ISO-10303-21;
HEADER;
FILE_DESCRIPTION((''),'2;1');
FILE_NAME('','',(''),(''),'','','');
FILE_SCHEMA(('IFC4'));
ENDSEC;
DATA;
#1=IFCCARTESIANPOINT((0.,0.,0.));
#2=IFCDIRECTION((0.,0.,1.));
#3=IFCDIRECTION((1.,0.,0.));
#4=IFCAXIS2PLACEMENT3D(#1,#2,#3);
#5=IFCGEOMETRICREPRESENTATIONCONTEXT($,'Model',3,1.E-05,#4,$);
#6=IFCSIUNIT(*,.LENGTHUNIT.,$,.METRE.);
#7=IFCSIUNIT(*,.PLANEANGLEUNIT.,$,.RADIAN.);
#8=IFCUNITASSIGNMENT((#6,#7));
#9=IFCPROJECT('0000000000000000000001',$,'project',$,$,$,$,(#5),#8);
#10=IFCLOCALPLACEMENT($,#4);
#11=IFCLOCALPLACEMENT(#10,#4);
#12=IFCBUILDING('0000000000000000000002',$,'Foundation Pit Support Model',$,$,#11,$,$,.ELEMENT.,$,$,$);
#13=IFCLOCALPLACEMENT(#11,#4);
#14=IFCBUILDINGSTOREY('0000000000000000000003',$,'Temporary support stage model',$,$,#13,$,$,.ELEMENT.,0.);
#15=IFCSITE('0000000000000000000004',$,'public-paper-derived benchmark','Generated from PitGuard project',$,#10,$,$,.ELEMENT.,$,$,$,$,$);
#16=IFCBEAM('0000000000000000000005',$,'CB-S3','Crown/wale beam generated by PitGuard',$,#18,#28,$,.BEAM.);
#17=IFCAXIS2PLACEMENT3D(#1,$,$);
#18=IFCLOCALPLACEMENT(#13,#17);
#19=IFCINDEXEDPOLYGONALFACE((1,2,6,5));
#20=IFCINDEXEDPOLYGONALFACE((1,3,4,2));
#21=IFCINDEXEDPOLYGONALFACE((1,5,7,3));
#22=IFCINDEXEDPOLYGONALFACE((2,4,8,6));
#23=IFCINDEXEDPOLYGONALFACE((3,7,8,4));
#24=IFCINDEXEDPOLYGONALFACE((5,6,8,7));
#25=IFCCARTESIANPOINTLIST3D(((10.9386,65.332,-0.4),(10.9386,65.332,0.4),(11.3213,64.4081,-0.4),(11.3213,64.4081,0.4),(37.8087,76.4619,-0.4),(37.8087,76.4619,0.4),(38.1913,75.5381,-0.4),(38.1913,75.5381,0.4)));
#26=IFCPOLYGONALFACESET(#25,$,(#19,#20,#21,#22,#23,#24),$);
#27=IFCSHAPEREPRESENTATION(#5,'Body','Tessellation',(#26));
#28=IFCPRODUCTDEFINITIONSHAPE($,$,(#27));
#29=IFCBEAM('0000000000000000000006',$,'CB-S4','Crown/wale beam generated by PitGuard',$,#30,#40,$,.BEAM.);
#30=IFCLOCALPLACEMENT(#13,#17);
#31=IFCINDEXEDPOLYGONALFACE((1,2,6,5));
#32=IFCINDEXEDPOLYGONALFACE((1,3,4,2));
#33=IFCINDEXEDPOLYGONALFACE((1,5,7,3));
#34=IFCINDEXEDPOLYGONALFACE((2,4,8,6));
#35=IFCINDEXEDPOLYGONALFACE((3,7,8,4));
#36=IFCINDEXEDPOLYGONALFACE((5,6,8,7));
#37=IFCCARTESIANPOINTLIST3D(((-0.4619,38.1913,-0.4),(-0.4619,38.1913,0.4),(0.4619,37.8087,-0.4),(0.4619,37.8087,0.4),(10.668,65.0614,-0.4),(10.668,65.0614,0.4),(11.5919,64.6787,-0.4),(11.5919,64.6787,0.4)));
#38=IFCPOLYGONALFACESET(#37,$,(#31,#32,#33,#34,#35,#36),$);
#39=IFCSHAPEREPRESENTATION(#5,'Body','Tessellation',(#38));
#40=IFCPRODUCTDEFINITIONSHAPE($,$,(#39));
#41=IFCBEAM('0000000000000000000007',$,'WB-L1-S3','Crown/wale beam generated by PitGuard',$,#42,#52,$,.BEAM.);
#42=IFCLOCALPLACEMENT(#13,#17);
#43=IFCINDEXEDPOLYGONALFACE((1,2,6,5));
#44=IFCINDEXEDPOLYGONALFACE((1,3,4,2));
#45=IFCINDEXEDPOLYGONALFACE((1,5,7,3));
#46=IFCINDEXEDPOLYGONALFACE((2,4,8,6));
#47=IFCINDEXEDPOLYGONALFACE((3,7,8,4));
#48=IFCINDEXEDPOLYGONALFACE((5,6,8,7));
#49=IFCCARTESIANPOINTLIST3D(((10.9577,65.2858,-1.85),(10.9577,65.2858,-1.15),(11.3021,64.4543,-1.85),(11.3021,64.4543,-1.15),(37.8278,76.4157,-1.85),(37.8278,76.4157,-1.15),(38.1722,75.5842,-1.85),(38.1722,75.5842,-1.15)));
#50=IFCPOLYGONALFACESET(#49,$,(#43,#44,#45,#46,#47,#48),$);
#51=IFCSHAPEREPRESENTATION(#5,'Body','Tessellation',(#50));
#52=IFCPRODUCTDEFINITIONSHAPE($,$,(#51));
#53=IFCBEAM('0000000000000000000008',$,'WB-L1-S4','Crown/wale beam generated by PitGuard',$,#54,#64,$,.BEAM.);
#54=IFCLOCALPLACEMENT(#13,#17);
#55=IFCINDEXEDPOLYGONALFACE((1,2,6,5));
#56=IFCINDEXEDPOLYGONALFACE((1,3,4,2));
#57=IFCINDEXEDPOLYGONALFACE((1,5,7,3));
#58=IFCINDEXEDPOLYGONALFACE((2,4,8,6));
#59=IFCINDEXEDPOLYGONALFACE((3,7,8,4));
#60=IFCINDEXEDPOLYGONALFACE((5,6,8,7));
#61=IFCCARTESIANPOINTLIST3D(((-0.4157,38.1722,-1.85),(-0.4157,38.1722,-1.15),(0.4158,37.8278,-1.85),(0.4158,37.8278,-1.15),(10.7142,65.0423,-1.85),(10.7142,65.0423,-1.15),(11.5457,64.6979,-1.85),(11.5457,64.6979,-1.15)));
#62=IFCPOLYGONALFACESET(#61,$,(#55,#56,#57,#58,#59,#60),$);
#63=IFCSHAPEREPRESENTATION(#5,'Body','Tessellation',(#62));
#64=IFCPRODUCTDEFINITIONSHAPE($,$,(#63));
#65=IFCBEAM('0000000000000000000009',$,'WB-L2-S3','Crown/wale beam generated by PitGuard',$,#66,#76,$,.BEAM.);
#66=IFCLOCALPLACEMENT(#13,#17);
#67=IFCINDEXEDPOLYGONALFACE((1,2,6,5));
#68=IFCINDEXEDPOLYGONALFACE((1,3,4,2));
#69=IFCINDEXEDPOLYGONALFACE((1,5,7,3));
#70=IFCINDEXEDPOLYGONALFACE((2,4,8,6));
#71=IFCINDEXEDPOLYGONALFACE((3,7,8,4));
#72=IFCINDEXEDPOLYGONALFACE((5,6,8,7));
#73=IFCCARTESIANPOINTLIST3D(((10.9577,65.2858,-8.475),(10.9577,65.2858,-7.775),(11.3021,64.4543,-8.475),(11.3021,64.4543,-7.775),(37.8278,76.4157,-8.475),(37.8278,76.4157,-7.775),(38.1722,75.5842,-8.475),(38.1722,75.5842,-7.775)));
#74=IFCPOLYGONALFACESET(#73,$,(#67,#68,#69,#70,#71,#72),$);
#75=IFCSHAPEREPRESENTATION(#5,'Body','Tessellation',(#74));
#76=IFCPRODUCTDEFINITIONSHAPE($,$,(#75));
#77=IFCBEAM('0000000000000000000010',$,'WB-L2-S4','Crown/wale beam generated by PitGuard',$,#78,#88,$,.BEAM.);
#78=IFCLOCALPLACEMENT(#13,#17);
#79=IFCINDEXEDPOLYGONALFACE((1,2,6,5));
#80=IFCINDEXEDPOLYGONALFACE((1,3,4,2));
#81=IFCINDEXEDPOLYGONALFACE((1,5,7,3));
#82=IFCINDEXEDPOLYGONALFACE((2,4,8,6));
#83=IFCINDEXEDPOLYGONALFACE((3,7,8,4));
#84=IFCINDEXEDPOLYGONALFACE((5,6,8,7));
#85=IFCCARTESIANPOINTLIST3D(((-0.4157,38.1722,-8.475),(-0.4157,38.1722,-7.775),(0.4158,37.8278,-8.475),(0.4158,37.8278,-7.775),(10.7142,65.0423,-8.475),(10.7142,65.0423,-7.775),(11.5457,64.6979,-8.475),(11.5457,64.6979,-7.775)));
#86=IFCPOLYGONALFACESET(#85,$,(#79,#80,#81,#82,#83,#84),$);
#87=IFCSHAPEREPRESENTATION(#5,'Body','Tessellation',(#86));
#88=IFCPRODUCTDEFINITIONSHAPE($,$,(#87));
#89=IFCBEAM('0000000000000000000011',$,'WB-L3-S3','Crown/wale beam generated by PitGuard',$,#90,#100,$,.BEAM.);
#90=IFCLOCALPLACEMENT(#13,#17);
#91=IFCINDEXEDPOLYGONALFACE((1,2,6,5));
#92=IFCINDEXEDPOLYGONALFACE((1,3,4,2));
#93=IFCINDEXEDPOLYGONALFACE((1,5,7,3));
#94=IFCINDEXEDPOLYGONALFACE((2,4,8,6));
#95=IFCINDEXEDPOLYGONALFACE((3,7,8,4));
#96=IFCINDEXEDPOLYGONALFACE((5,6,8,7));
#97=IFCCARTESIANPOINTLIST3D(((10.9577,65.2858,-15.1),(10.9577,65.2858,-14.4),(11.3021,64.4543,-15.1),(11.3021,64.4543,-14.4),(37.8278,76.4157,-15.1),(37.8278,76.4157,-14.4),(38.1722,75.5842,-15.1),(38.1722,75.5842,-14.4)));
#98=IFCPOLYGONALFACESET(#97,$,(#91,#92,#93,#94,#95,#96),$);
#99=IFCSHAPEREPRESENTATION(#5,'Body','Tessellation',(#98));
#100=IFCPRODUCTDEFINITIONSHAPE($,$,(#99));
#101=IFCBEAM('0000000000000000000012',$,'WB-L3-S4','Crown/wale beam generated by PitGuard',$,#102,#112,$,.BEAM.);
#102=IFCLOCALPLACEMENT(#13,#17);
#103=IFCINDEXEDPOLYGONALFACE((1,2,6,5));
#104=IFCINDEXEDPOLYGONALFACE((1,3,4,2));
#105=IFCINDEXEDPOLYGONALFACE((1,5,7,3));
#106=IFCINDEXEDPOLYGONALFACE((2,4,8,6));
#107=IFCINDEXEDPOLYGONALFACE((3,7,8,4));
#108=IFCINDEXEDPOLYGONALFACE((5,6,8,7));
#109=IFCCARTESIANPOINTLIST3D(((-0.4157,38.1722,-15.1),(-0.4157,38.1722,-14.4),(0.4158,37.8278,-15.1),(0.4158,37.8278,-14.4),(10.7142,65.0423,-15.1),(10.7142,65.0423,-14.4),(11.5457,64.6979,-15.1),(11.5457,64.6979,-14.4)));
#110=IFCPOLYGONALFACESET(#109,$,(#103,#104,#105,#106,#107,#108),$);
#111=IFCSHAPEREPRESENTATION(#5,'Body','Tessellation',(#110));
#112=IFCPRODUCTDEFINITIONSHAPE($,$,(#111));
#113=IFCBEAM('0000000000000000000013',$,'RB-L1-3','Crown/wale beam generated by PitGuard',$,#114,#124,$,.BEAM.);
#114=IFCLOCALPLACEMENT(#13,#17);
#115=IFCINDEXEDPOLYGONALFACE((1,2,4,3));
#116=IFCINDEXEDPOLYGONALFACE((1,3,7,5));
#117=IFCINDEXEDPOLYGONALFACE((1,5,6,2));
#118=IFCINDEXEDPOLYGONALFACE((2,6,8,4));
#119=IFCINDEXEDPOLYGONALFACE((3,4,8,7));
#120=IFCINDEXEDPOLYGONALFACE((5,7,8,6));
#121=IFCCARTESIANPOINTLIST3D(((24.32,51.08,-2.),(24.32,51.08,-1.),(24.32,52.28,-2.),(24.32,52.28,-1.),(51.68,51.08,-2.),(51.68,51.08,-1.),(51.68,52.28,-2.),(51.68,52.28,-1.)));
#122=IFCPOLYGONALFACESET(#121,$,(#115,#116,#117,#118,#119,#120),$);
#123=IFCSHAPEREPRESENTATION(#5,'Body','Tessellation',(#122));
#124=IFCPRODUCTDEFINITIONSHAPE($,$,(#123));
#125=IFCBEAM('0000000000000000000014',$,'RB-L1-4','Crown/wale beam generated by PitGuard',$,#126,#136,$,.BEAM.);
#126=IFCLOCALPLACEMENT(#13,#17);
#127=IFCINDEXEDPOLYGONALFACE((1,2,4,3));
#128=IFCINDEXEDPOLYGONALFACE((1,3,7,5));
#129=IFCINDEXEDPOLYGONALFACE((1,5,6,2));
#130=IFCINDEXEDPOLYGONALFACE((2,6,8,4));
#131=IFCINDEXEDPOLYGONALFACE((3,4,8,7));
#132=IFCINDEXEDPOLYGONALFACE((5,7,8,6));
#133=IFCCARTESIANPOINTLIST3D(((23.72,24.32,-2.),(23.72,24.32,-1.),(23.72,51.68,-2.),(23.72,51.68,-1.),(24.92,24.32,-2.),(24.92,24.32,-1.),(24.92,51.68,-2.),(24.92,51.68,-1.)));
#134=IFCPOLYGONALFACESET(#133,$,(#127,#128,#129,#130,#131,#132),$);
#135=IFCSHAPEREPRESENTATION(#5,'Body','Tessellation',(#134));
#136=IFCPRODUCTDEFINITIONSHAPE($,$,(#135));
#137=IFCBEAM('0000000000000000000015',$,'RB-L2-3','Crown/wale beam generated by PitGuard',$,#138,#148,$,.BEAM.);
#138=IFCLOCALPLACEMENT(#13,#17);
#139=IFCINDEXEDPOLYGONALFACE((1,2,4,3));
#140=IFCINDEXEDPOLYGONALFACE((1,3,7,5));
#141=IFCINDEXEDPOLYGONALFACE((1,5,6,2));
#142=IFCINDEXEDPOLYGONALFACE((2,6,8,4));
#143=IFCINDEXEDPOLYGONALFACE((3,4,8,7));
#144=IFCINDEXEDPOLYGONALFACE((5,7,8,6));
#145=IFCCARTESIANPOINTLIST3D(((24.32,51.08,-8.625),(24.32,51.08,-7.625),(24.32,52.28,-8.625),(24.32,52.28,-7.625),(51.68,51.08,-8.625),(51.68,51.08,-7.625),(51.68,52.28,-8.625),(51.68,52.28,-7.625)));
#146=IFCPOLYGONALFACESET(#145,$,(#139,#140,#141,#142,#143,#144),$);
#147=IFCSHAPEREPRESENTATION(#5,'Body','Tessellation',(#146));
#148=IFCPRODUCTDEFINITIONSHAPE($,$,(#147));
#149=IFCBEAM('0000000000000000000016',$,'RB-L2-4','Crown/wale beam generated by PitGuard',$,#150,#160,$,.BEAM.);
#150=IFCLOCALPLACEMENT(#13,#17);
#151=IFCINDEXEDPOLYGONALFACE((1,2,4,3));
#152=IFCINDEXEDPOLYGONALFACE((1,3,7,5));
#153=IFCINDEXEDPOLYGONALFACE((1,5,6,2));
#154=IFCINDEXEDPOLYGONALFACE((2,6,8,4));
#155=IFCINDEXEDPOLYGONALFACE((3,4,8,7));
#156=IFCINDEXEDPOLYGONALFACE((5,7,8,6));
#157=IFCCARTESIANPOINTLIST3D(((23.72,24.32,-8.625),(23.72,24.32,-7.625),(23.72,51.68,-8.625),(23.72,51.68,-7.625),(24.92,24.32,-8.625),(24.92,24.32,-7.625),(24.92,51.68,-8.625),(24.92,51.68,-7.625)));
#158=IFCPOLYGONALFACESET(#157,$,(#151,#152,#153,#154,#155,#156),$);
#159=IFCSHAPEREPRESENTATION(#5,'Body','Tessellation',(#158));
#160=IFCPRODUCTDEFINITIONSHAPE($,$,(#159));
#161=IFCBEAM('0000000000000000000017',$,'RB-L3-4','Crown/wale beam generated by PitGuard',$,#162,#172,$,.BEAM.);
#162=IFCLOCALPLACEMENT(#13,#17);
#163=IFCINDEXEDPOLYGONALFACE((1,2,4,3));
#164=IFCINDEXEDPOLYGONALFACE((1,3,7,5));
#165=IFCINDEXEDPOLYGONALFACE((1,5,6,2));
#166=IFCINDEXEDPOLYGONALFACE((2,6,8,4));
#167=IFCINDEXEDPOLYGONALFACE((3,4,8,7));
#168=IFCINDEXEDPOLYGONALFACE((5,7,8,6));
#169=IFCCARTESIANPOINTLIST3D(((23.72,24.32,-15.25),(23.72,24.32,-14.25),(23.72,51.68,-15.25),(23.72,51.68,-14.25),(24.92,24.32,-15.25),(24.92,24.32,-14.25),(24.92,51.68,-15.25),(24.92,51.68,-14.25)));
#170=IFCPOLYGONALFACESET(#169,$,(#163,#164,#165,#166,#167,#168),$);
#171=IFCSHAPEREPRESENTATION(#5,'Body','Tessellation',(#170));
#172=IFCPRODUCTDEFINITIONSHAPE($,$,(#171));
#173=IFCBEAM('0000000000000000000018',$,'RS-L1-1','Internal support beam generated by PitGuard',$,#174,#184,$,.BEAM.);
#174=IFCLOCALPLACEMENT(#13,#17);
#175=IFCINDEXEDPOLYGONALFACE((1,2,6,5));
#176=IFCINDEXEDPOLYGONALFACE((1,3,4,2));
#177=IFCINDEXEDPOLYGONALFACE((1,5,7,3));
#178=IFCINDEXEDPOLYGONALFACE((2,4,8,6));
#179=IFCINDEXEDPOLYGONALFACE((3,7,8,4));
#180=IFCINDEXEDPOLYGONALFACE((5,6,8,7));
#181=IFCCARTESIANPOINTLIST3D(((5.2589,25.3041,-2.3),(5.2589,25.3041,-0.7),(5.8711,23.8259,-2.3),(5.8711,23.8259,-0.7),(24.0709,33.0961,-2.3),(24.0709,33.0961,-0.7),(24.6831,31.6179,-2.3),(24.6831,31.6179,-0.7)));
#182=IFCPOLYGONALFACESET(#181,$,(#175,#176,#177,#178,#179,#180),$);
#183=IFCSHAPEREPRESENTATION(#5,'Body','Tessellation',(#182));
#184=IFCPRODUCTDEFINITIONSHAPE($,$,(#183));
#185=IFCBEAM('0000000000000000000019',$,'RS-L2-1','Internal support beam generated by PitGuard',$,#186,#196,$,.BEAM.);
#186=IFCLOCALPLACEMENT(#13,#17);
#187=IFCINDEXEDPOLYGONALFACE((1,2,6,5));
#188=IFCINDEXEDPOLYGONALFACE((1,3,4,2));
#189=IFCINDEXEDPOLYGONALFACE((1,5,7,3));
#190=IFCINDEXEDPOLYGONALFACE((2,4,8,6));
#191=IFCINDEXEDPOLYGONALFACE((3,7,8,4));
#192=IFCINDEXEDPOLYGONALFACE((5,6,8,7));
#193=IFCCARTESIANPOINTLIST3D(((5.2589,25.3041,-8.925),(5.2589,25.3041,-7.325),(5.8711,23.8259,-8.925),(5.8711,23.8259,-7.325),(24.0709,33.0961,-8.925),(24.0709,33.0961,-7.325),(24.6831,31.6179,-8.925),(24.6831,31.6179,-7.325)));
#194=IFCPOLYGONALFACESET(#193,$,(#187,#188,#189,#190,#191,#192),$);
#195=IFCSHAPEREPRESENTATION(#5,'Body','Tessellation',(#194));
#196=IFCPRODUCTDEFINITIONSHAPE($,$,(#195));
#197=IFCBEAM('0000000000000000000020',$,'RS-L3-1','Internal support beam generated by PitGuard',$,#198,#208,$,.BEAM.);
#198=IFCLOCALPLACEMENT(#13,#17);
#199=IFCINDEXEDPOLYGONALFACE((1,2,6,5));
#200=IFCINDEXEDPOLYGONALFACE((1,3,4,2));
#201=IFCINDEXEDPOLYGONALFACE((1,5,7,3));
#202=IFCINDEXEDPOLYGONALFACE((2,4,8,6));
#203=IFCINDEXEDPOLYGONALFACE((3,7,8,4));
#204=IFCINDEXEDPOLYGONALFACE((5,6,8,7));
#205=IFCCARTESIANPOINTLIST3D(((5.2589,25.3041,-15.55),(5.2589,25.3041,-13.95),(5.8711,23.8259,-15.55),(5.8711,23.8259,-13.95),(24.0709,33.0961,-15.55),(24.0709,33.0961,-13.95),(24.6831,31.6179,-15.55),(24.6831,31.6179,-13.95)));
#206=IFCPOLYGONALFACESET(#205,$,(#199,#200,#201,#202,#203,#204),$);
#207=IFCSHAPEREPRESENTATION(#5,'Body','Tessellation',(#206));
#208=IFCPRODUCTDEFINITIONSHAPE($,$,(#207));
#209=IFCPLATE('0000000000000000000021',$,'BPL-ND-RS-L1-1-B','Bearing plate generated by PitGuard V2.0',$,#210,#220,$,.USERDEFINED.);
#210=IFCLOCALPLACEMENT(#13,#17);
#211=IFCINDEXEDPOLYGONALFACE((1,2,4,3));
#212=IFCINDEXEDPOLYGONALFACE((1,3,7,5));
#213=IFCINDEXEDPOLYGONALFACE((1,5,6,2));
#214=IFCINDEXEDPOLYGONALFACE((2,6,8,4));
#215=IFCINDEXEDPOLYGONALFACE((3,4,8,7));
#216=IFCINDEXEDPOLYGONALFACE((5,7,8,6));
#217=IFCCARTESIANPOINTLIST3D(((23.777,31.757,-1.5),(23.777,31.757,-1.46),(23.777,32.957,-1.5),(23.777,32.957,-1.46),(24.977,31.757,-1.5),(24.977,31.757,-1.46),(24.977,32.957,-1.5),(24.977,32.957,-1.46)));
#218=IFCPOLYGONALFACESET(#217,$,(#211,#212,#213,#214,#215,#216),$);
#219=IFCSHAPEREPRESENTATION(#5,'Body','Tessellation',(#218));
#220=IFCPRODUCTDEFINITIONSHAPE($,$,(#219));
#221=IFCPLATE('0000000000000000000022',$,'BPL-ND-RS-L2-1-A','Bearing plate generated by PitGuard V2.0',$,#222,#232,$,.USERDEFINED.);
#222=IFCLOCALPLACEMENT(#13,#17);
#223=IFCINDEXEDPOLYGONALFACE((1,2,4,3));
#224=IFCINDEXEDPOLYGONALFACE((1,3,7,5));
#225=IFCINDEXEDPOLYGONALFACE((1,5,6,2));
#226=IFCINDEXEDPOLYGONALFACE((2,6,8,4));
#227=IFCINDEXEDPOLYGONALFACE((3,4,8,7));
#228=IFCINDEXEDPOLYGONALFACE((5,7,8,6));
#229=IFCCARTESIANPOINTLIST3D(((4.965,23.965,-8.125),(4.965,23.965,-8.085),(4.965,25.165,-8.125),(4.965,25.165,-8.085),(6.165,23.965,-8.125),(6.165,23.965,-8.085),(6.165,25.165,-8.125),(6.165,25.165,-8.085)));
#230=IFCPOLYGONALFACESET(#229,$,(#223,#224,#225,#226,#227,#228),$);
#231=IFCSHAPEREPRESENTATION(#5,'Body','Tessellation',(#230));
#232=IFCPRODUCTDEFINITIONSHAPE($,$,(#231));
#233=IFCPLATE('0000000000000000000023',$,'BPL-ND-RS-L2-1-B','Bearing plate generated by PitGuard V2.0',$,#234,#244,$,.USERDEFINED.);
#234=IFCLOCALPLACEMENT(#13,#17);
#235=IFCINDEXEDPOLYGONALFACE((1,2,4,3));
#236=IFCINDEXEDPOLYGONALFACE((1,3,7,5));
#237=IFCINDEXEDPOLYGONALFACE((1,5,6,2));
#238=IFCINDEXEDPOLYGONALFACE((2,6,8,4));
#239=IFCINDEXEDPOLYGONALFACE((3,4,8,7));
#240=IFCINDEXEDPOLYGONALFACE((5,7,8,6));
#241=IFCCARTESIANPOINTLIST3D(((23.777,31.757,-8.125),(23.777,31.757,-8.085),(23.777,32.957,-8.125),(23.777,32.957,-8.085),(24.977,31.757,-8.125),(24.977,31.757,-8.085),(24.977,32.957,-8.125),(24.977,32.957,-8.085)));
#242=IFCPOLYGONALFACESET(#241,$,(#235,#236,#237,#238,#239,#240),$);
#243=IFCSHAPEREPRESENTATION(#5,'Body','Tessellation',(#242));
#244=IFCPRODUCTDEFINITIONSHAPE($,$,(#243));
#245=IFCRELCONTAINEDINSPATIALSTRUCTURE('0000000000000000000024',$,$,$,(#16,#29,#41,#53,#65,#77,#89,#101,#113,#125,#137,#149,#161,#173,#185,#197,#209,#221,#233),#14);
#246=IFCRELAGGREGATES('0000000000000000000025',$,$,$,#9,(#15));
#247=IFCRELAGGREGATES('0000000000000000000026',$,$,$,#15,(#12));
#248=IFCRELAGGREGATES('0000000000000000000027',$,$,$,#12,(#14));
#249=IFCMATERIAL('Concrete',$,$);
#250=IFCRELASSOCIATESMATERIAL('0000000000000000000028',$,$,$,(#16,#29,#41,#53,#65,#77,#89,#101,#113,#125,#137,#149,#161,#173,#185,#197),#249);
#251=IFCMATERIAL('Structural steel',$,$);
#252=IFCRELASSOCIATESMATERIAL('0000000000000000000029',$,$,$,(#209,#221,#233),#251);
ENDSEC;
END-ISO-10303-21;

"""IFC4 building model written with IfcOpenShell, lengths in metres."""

from ifc_helpers import new_model, si_unit, frame, origin_with_axes, origin_2d, place, context, project, spatial, rectangle, extrude, material, element, save


model = new_model("IFC4")

# Units and contexts
model_context = context("Model", 3, precision=1e-05, world=origin_with_axes())
ifc_project = project(units=[si_unit("LENGTHUNIT", "METRE"), si_unit("PLANEANGLEUNIT", "RADIAN")], contexts=[model_context])

# Site, building, storey
site_placement = place(None, origin_with_axes())
site = spatial("IfcSite", under=ifc_project, at=site_placement, Name="public-paper-derived benchmark", Description="Generated from PitGuard project", CompositionType="ELEMENT")
building_placement = place(site_placement, origin_with_axes())
building = spatial("IfcBuilding", under=site, at=building_placement, Name="Foundation Pit Support Model", CompositionType="ELEMENT")
storey_placement = place(building_placement, origin_with_axes())
storey = spatial("IfcBuildingStorey", under=building, at=storey_placement, Name="Temporary support stage model", CompositionType="ELEMENT", Elevation=0.0)

# Beams
ifc_material_1 = material(Name="Concrete")
for number, where, z_axis, x_axis, name in (
    (1, (24.565, 70.435, -0.4), (0.0, 0.0, 1.0), (-0.92388, -0.382683, 0.0), "CB-S3"),
    (2, (5.565, 51.435, -0.4), (0.0, 0.0, 1.0), (-0.382683, -0.92388, 0.0), "CB-S4"),
):
    element("IfcBeam", number, at=place(storey_placement, frame(where, z_axis=z_axis, x_axis=x_axis)), inside=storey, material=ifc_material_1, Name=name, Description="Crown/wale beam generated by PitGuard", PredefinedType="BEAM", context=model_context, shape_type="SweptSolid", body=[
        extrude(rectangle(XDim=29.0839, YDim=1.0, at=origin_2d()), origin_with_axes(), (0.0, 0.0, 1.0), 0.8),
    ])
for number, where, z_axis, x_axis, name in (
    (3, (24.565, 70.435, -1.85), (0.0, 0.0, 1.0), (-0.92388, -0.382683, 0.0), "WB-L1-S3"),
    (4, (5.565, 51.435, -1.85), (0.0, 0.0, 1.0), (-0.382683, -0.92388, 0.0), "WB-L1-S4"),
    (5, (24.565, 70.435, -8.475), (0.0, 0.0, 1.0), (-0.92388, -0.382683, 0.0), "WB-L2-S3"),
    (6, (5.565, 51.435, -8.475), (0.0, 0.0, 1.0), (-0.382683, -0.92388, 0.0), "WB-L2-S4"),
    (7, (24.565, 70.435, -15.1), (0.0, 0.0, 1.0), (-0.92388, -0.382683, 0.0), "WB-L3-S3"),
    (8, (5.565, 51.435, -15.1), (0.0, 0.0, 1.0), (-0.382683, -0.92388, 0.0), "WB-L3-S4"),
):
    element("IfcBeam", number, at=place(storey_placement, frame(where, z_axis=z_axis, x_axis=x_axis)), inside=storey, material=ifc_material_1, Name=name, Description="Crown/wale beam generated by PitGuard", PredefinedType="BEAM", context=model_context, shape_type="SweptSolid", body=[
        extrude(rectangle(XDim=29.0839, YDim=0.9, at=origin_2d()), origin_with_axes(), (0.0, 0.0, 1.0), 0.7),
    ])
for number, where, z_axis, x_axis, name in (
    (9, (38.0, 51.68, -2.0), (0.0, 0.0, 1.0), (-1.0, 0.0, 0.0), "RB-L1-3"),
    (10, (24.32, 38.0, -2.0), (0.0, 0.0, 1.0), (0.0, -1.0, 0.0), "RB-L1-4"),
    (11, (38.0, 51.68, -8.625), (0.0, 0.0, 1.0), (-1.0, 0.0, 0.0), "RB-L2-3"),
    (12, (24.32, 38.0, -8.625), (0.0, 0.0, 1.0), (0.0, -1.0, 0.0), "RB-L2-4"),
    (13, (24.32, 38.0, -15.25), (0.0, 0.0, 1.0), (0.0, -1.0, 0.0), "RB-L3-4"),
):
    element("IfcBeam", number, at=place(storey_placement, frame(where, z_axis=z_axis, x_axis=x_axis)), inside=storey, material=ifc_material_1, Name=name, Description="Crown/wale beam generated by PitGuard", PredefinedType="BEAM", context=model_context, shape_type="SweptSolid", body=[
        extrude(rectangle(XDim=27.36, YDim=1.2, at=origin_2d()), origin_with_axes(), (0.0, 0.0, 1.0), 1.0),
    ])
for number, where, z_axis, x_axis, name in (
    (14, (14.971, 28.461, -2.3), (0.0, 0.0, 1.0), (0.923883, 0.382676, 0.0), "RS-L1-1"),
    (15, (14.971, 28.461, -8.925), (0.0, 0.0, 1.0), (0.923883, 0.382676, 0.0), "RS-L2-1"),
    (16, (14.971, 28.461, -15.55), (0.0, 0.0, 1.0), (0.923883, 0.382676, 0.0), "RS-L3-1"),
):
    element("IfcBeam", number, at=place(storey_placement, frame(where, z_axis=z_axis, x_axis=x_axis)), inside=storey, material=ifc_material_1, Name=name, Description="Internal support beam generated by PitGuard", PredefinedType="BEAM", context=model_context, shape_type="SweptSolid", body=[
        extrude(rectangle(XDim=20.3619, YDim=1.6, at=origin_2d()), origin_with_axes(), (0.0, 0.0, 1.0), 1.6),
    ])

# Plates
ifc_material_2 = material(Name="Structural steel")
for number, where, z_axis, x_axis, name in (
    (17, (24.377, 32.357, -1.5), (0.0, 0.0, 1.0), (1.0, 0.0, 0.0), "BPL-ND-RS-L1-1-B"),
    (18, (5.565, 24.565, -8.125), (0.0, 0.0, 1.0), (1.0, 0.0, 0.0), "BPL-ND-RS-L2-1-A"),
    (19, (24.377, 32.357, -8.125), (0.0, 0.0, 1.0), (1.0, 0.0, 0.0), "BPL-ND-RS-L2-1-B"),
):
    element("IfcPlate", number, at=place(storey_placement, frame(where, z_axis=z_axis, x_axis=x_axis)), inside=storey, material=ifc_material_2, Name=name, Description="Bearing plate generated by PitGuard V2.0", PredefinedType="USERDEFINED", context=model_context, shape_type="SweptSolid", body=[
        extrude(rectangle(XDim=1.2, YDim=1.2, at=origin_2d()), origin_with_axes(), (0.0, 0.0, 1.0), 0.04),
    ])

save(model, "model.ifc")
